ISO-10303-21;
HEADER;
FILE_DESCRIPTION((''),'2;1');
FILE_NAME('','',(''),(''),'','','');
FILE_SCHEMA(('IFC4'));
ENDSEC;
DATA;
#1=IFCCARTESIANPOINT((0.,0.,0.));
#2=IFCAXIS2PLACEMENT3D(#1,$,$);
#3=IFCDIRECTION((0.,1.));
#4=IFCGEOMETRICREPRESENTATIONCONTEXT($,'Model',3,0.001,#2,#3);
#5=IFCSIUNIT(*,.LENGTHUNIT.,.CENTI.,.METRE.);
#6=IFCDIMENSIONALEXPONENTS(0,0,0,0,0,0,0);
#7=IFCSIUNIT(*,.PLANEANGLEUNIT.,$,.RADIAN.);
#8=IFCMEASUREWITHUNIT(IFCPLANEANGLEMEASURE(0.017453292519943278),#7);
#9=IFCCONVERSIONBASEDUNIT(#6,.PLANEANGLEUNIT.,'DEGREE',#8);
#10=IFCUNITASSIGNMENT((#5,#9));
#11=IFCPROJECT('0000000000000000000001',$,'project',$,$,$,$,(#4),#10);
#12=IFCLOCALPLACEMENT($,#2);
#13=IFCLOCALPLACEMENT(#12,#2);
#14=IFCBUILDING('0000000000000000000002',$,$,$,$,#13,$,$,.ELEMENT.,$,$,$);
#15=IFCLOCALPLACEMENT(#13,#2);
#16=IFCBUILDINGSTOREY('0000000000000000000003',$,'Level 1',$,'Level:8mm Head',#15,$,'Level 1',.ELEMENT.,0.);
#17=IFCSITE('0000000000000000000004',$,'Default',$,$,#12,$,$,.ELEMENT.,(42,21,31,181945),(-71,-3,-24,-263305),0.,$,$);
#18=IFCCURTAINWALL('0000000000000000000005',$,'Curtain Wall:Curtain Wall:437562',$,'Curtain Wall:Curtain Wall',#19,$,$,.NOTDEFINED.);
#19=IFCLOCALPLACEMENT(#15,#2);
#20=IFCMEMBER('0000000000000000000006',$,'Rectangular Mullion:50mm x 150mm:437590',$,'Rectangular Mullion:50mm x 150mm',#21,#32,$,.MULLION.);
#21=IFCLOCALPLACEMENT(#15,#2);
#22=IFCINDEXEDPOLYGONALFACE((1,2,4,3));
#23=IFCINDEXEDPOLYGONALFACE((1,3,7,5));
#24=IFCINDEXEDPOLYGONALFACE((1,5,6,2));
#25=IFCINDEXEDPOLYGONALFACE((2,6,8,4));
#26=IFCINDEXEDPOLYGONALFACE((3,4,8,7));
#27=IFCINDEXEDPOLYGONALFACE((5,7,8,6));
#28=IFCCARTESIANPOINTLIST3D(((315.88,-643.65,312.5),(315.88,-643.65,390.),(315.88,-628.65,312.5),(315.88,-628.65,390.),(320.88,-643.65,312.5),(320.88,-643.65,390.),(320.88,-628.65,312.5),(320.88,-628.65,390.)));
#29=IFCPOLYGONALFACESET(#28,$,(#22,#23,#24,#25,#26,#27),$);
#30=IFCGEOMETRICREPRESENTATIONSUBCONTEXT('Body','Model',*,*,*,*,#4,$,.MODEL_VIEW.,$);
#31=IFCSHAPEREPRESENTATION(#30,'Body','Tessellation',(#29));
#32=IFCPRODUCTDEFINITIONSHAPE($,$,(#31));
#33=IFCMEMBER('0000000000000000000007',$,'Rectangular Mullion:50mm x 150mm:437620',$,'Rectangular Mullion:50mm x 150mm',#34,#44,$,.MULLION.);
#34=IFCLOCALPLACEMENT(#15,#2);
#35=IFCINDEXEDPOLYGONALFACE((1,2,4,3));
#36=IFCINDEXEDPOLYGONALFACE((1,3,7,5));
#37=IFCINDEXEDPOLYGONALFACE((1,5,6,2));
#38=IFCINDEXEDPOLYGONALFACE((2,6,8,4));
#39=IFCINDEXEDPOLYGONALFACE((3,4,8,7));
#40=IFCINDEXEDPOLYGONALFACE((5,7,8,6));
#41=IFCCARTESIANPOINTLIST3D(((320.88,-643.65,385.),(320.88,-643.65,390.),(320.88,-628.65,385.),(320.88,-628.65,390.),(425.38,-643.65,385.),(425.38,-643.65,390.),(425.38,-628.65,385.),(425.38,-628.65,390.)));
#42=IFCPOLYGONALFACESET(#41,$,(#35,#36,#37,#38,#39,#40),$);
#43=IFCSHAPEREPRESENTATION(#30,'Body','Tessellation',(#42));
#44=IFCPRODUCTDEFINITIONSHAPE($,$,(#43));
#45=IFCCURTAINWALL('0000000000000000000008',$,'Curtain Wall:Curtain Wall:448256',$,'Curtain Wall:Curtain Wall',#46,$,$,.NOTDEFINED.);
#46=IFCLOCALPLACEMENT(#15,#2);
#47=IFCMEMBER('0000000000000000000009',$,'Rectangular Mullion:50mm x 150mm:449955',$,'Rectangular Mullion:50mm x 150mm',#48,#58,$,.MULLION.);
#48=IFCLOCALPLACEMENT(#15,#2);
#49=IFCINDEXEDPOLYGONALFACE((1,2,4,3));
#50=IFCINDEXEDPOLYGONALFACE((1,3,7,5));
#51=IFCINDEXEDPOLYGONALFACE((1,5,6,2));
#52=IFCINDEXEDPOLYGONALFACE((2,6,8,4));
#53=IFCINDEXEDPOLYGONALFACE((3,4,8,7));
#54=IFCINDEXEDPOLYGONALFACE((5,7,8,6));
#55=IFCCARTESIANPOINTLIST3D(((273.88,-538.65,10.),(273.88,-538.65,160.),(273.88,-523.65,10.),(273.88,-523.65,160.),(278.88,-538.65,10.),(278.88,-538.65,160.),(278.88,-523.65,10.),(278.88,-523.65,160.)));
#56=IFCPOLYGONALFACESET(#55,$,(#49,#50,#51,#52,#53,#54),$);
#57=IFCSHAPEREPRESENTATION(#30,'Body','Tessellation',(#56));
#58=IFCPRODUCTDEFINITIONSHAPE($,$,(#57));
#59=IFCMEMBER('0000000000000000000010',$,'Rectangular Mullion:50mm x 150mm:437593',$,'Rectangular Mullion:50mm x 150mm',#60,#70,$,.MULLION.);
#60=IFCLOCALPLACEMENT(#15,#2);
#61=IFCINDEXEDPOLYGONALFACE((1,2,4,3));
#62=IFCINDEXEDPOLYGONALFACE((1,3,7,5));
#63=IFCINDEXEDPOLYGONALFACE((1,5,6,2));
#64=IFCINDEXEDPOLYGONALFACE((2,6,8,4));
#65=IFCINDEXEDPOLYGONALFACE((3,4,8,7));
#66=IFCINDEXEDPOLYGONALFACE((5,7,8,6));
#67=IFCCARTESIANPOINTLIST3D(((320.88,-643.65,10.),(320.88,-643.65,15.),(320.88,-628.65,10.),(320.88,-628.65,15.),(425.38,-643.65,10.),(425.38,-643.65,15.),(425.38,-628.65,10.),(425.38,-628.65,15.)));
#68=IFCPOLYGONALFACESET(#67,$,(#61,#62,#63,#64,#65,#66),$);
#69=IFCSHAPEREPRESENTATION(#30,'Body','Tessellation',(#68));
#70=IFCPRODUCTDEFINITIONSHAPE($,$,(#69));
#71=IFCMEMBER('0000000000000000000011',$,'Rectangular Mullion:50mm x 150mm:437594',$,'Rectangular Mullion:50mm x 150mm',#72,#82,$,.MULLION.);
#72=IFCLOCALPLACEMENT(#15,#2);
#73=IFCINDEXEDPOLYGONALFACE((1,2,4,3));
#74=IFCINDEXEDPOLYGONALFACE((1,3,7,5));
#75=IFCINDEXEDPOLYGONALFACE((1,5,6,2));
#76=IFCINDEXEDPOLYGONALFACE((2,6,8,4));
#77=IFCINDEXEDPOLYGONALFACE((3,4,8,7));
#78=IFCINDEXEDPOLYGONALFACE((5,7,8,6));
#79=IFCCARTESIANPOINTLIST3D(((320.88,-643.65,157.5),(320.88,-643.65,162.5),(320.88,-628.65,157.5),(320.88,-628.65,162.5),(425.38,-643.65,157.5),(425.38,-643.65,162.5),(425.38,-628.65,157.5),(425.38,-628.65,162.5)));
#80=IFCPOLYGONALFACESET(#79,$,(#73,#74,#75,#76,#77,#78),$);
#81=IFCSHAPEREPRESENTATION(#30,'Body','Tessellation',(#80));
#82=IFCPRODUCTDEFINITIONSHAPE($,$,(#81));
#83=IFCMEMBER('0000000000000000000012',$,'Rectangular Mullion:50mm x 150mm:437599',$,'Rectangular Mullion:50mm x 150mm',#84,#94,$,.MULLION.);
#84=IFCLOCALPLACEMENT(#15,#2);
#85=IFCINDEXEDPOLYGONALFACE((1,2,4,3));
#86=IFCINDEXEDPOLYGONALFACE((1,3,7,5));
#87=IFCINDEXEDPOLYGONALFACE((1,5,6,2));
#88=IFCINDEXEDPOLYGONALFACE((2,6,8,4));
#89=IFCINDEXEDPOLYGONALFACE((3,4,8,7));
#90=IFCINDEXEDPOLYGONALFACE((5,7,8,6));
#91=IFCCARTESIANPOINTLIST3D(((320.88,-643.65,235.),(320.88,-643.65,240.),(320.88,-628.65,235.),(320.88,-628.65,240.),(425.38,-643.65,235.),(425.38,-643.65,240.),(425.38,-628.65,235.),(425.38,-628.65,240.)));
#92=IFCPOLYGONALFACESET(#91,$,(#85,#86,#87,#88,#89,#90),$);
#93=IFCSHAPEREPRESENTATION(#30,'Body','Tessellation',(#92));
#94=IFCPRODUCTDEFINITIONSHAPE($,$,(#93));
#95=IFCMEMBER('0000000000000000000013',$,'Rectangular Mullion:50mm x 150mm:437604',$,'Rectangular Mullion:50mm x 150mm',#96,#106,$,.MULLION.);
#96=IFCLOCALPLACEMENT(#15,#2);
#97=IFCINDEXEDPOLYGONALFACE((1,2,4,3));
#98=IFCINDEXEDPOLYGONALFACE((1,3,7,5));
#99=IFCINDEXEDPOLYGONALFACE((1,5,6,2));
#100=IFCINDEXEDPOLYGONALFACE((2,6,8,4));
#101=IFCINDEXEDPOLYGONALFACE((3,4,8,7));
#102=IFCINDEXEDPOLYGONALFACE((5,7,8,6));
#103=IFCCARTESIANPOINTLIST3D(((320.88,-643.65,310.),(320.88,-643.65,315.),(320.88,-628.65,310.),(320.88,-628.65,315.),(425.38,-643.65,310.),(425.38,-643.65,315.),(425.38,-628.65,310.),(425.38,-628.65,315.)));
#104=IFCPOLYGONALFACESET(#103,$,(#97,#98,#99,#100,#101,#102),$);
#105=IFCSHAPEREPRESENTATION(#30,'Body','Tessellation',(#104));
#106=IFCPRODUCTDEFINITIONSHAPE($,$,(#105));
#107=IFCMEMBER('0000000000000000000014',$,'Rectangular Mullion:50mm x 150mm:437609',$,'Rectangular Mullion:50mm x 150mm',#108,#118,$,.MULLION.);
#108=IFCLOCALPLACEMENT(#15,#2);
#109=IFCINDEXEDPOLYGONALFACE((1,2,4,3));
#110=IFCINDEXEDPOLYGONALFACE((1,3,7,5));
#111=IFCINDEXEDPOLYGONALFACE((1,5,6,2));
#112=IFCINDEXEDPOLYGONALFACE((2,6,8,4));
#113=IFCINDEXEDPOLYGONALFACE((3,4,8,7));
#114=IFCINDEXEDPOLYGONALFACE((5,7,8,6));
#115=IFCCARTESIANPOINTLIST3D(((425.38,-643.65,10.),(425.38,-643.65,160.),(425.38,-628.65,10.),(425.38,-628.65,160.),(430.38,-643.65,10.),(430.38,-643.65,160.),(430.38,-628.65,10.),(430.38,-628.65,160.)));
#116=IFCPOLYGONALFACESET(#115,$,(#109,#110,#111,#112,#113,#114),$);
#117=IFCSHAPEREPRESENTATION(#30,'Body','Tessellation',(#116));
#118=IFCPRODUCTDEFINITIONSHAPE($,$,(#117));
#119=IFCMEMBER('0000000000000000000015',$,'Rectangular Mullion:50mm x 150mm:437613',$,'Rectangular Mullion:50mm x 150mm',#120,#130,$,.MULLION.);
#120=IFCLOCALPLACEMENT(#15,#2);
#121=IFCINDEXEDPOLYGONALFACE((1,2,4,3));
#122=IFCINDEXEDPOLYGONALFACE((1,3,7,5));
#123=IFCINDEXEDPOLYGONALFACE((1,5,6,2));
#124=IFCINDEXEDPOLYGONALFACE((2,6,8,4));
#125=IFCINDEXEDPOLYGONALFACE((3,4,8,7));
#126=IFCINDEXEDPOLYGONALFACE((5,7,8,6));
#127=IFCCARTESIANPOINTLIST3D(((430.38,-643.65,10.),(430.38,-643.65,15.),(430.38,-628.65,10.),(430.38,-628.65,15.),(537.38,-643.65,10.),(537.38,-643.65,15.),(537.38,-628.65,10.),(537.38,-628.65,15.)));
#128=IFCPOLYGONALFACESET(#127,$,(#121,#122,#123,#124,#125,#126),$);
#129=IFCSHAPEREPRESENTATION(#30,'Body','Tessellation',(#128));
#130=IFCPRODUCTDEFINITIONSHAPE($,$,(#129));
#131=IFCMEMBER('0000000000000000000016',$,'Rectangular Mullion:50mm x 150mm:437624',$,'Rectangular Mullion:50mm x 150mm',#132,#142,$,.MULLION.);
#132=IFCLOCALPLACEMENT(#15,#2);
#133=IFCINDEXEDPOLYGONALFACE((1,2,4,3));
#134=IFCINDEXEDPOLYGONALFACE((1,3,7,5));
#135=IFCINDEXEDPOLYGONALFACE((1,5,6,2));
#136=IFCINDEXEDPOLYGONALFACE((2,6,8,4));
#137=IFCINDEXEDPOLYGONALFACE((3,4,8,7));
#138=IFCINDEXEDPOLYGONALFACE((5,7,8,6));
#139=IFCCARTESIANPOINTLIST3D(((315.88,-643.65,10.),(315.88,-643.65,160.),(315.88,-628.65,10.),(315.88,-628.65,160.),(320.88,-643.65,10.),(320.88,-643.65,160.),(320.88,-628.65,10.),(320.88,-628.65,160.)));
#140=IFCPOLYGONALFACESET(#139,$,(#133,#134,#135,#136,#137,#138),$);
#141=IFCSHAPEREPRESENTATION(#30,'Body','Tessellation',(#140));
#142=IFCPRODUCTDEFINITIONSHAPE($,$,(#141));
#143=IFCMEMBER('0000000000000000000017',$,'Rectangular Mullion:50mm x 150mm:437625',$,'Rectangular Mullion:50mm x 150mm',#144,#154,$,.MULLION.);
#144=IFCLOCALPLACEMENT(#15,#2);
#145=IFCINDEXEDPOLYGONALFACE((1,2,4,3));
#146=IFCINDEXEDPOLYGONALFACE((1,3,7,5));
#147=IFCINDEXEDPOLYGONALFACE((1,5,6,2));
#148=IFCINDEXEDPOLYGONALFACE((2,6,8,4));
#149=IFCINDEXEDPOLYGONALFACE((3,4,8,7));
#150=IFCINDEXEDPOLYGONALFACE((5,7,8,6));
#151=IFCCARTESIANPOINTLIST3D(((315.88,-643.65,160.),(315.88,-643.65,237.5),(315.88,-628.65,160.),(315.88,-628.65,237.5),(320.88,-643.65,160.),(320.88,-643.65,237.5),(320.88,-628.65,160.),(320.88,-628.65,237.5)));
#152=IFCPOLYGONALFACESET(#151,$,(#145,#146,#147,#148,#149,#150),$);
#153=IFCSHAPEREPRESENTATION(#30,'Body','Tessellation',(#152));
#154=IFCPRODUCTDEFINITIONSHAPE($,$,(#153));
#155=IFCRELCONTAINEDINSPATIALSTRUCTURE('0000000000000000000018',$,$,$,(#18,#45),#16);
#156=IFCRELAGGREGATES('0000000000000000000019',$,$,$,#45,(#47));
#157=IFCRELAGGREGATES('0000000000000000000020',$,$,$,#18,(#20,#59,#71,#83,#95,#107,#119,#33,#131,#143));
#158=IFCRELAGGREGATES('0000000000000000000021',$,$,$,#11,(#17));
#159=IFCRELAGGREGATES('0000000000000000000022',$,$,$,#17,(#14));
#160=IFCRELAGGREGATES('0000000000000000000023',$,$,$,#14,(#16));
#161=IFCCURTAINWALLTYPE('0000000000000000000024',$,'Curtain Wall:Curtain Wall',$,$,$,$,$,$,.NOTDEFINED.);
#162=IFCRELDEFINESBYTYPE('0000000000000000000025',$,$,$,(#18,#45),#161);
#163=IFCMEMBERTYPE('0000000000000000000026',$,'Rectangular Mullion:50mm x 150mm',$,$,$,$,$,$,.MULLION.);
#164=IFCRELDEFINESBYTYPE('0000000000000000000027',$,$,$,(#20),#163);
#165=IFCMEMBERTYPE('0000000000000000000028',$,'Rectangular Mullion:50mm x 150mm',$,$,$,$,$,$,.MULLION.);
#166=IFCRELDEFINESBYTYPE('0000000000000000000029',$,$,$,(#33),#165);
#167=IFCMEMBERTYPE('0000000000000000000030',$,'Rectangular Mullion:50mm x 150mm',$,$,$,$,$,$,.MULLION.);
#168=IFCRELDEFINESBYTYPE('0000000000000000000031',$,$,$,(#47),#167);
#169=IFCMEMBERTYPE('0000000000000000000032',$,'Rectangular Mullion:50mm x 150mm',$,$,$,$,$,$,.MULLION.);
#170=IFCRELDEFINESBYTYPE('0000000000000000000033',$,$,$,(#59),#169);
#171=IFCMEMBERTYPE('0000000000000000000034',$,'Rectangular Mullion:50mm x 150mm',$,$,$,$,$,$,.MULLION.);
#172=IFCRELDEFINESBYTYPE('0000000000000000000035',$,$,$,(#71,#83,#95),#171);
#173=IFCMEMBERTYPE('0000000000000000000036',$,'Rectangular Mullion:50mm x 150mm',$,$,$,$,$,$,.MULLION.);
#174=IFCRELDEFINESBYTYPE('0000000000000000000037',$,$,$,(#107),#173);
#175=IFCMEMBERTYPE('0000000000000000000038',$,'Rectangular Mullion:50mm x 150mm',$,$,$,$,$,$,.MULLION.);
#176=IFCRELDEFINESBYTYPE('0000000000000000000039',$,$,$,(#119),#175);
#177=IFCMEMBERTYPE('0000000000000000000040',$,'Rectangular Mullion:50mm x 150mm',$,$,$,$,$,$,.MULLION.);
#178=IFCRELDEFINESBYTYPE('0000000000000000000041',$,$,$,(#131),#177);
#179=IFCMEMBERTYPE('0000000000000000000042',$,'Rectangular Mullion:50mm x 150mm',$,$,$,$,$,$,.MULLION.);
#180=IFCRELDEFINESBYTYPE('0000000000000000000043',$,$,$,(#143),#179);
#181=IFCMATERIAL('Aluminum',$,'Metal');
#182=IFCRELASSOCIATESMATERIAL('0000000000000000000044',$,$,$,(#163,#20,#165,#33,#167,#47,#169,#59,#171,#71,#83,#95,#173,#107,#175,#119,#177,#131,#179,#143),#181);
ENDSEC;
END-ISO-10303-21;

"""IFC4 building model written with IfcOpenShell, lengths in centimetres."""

from ifc_helpers import new_model, entity, si_unit, converted_unit, direction, frame, origin, place, context, subcontext, project, spatial, indexed_curve, outline, extrude, source, transform, mapped, material, type_object, type_shapes, element, aggregate, save


model = new_model("IFC4")

# Units and contexts
model_context = context("Model", 3, precision=0.001, world=origin(), true_north=direction((0.0, 1.0)))
body_context = subcontext(model_context, "Body", "Model", "MODEL_VIEW")
ifc_project = project(units=[si_unit("LENGTHUNIT", "METRE", prefix="CENTI"), converted_unit("PLANEANGLEUNIT", "DEGREE", entity("IfcPlaneAngleMeasure", 0.017453292519943278), si_unit("PLANEANGLEUNIT", "RADIAN"), dimensions=[0, 0, 0, 0, 0, 0, 0])], contexts=[model_context])

# Site, building, storey
site_placement = place(None, origin())
site = spatial("IfcSite", under=ifc_project, at=site_placement, Name="Default", CompositionType="ELEMENT", RefLatitude=(42, 21, 31, 181945), RefLongitude=(-71, -3, -24, -263305), RefElevation=0.0)
building_placement = place(site_placement, origin())
building = spatial("IfcBuilding", under=site, at=building_placement, CompositionType="ELEMENT")
storey_placement = place(building_placement, origin())
storey = spatial("IfcBuildingStorey", under=building, at=storey_placement, Name="Level 1", ObjectType="Level:8mm Head", LongName="Level 1", CompositionType="ELEMENT", Elevation=0.0)

# Curtain wall, members
curtain_wall_type = type_object("IfcCurtainWallType", Name="Curtain Wall:Curtain Wall", PredefinedType="NOTDEFINED")
curtain_wall_1_placement = place(storey_placement, origin())
curtain_wall_1 = element("IfcCurtainWall", 1, at=curtain_wall_1_placement, inside=storey, type_object=curtain_wall_type, Name="Curtain Wall:Curtain Wall:437562", ObjectType="Curtain Wall:Curtain Wall", PredefinedType="NOTDEFINED")
ifc_material_1 = material(Name="Aluminum", Category="Metal")
member_type_1 = type_object("IfcMemberType", Name="Rectangular Mullion:50mm x 150mm", PredefinedType="MULLION", material=ifc_material_1)
shared_shape_1 = source(origin(), body_context, "Body", "SweptSolid", [
    extrude(outline(indexed_curve([(-2.5, -7.5), (2.5, -7.5), (2.5, 7.5), (-2.5, 7.5), (-2.5, -7.5)], self_intersect=False)), frame((-2.5, 0.0, -77.5), z_axis=(0.0, 0.0, 1.0), x_axis=(-1.0, 0.0, 0.0)), (0.0, 0.0, 1.0), 77.5),
])
type_shapes(member_type_1, [shared_shape_1])
member_1_placement = place(curtain_wall_1_placement, frame((315.88, -636.15, 390.0), z_axis=(0.0, 0.0, 1.0), x_axis=(-1.0, 0.0, 0.0)))
member_1 = element("IfcMember", 2, at=member_1_placement, type_object=member_type_1, material=ifc_material_1, Name="Rectangular Mullion:50mm x 150mm:437590", ObjectType="Rectangular Mullion:50mm x 150mm", PredefinedType="MULLION", context=body_context, shape_type="MappedRepresentation", body=[
    mapped(shared_shape_1, transform((0.0, 0.0, 0.0), scale=1.0)),
])
member_type_2 = type_object("IfcMemberType", Name="Rectangular Mullion:50mm x 150mm", PredefinedType="MULLION", material=ifc_material_1)
shared_shape_2 = source(origin(), body_context, "Body", "SweptSolid", [
    extrude(outline(indexed_curve([(-2.5, -7.5), (2.5, -7.5), (2.5, 7.5), (-2.5, 7.5), (-2.5, -7.5)], self_intersect=False)), frame((-2.5, 0.0, -104.5), z_axis=(0.0, 0.0, 1.0), x_axis=(-1.0, 0.0, 0.0)), (0.0, 0.0, 1.0), 104.5),
])
type_shapes(member_type_2, [shared_shape_2])
member_2_placement = place(curtain_wall_1_placement, frame((425.38, -636.15, 390.0), z_axis=(1.0, 0.0, 0.0), x_axis=(0.0, 0.0, 1.0)))
member_2 = element("IfcMember", 3, at=member_2_placement, type_object=member_type_2, material=ifc_material_1, Name="Rectangular Mullion:50mm x 150mm:437620", ObjectType="Rectangular Mullion:50mm x 150mm", PredefinedType="MULLION", context=body_context, shape_type="MappedRepresentation", body=[
    mapped(shared_shape_2, transform((0.0, 0.0, 0.0), scale=1.0)),
])

# Curtain wall, member
curtain_wall_2_placement = place(storey_placement, origin())
curtain_wall_2 = element("IfcCurtainWall", 4, at=curtain_wall_2_placement, inside=storey, type_object=curtain_wall_type, Name="Curtain Wall:Curtain Wall:448256", ObjectType="Curtain Wall:Curtain Wall", PredefinedType="NOTDEFINED")
member_type_3 = type_object("IfcMemberType", Name="Rectangular Mullion:50mm x 150mm", PredefinedType="MULLION", material=ifc_material_1)
shared_shape_3 = source(origin(), body_context, "Body", "SweptSolid", [
    extrude(outline(indexed_curve([(-2.5, -7.5), (2.5, -7.5), (2.5, 7.5), (-2.5, 7.5), (-2.5, -7.5)], self_intersect=False)), frame((-2.5, 0.0, -150.0), z_axis=(0.0, 0.0, 1.0), x_axis=(-1.0, 0.0, 0.0)), (0.0, 0.0, 1.0), 150.0),
])
type_shapes(member_type_3, [shared_shape_3])
member_3_placement = place(curtain_wall_2_placement, frame((278.88, -531.15, 10.0), z_axis=(0.0, 0.0, -1.0), x_axis=(1.0, 0.0, 0.0)))
member_3 = element("IfcMember", 5, at=member_3_placement, type_object=member_type_3, material=ifc_material_1, Name="Rectangular Mullion:50mm x 150mm:449955", ObjectType="Rectangular Mullion:50mm x 150mm", PredefinedType="MULLION", context=body_context, shape_type="MappedRepresentation", body=[
    mapped(shared_shape_3, transform((0.0, 0.0, 0.0), scale=1.0)),
])

# Members
member_type_4 = type_object("IfcMemberType", Name="Rectangular Mullion:50mm x 150mm", PredefinedType="MULLION", material=ifc_material_1)
shared_shape_4 = source(origin(), body_context, "Body", "SweptSolid", [
    extrude(outline(indexed_curve([(-2.5, -7.5), (2.5, -7.5), (2.5, 7.5), (-2.5, 7.5), (-2.5, -7.5)], self_intersect=False)), frame((-2.5, 0.0, -104.5), z_axis=(0.0, 0.0, 1.0), x_axis=(-1.0, 0.0, 0.0)), (0.0, 0.0, 1.0), 104.5),
])
type_shapes(member_type_4, [shared_shape_4])
member_4_placement = place(curtain_wall_1_placement, frame((320.88, -636.15, 10.0), z_axis=(-1.0, 0.0, 0.0), x_axis=(0.0, 0.0, -1.0)))
member_4 = element("IfcMember", 6, at=member_4_placement, type_object=member_type_4, material=ifc_material_1, Name="Rectangular Mullion:50mm x 150mm:437593", ObjectType="Rectangular Mullion:50mm x 150mm", PredefinedType="MULLION", context=body_context, shape_type="MappedRepresentation", body=[
    mapped(shared_shape_4, transform((0.0, 0.0, 0.0), scale=1.0)),
])
member_type_5 = type_object("IfcMemberType", Name="Rectangular Mullion:50mm x 150mm", PredefinedType="MULLION", material=ifc_material_1)
shared_shape_5 = source(origin(), body_context, "Body", "SweptSolid", [
    extrude(outline(indexed_curve([(-2.5, -7.5), (2.5, -7.5), (2.5, 7.5), (-2.5, 7.5), (-2.5, -7.5)], self_intersect=False)), frame((0.0, 0.0, -104.5), z_axis=(0.0, 0.0, 1.0), x_axis=(-1.0, 0.0, 0.0)), (0.0, 0.0, 1.0), 104.5),
])
type_shapes(member_type_5, [shared_shape_5])
member_5_placement = place(curtain_wall_1_placement, frame((425.38, -636.15, 160.0), z_axis=(1.0, 0.0, 0.0), x_axis=(0.0, 0.0, 1.0)))
member_5 = element("IfcMember", 7, at=member_5_placement, type_object=member_type_5, material=ifc_material_1, Name="Rectangular Mullion:50mm x 150mm:437594", ObjectType="Rectangular Mullion:50mm x 150mm", PredefinedType="MULLION", context=body_context, shape_type="MappedRepresentation", body=[
    mapped(shared_shape_5, transform((0.0, 0.0, 0.0), scale=1.0)),
])
member_6_placement = place(curtain_wall_1_placement, frame((425.38, -636.15, 237.5), z_axis=(1.0, 0.0, 0.0), x_axis=(0.0, 0.0, 1.0)))
member_6 = element("IfcMember", 8, at=member_6_placement, type_object=member_type_5, material=ifc_material_1, Name="Rectangular Mullion:50mm x 150mm:437599", ObjectType="Rectangular Mullion:50mm x 150mm", PredefinedType="MULLION", context=body_context, shape_type="MappedRepresentation", body=[
    mapped(shared_shape_5, transform((0.0, 0.0, 0.0), scale=1.0)),
])
member_7_placement = place(curtain_wall_1_placement, frame((425.38, -636.15, 312.5), z_axis=(1.0, 0.0, 0.0), x_axis=(0.0, 0.0, 1.0)))
member_7 = element("IfcMember", 9, at=member_7_placement, type_object=member_type_5, material=ifc_material_1, Name="Rectangular Mullion:50mm x 150mm:437604", ObjectType="Rectangular Mullion:50mm x 150mm", PredefinedType="MULLION", context=body_context, shape_type="MappedRepresentation", body=[
    mapped(shared_shape_5, transform((0.0, 0.0, 0.0), scale=1.0)),
])
member_type_6 = type_object("IfcMemberType", Name="Rectangular Mullion:50mm x 150mm", PredefinedType="MULLION", material=ifc_material_1)
shared_shape_6 = source(origin(), body_context, "Body", "SweptSolid", [
    extrude(outline(indexed_curve([(-2.5, -7.5), (2.5, -7.5), (2.5, 7.5), (-2.5, 7.5), (-2.5, -7.5)], self_intersect=False)), frame((0.0, 0.0, -150.0), z_axis=(0.0, 0.0, 1.0), x_axis=(-1.0, 0.0, 0.0)), (0.0, 0.0, 1.0), 150.0),
])
type_shapes(member_type_6, [shared_shape_6])
member_8_placement = place(curtain_wall_1_placement, frame((427.88, -636.15, 10.0), z_axis=(0.0, 0.0, -1.0), x_axis=(1.0, 0.0, 0.0)))
member_8 = element("IfcMember", 10, at=member_8_placement, type_object=member_type_6, material=ifc_material_1, Name="Rectangular Mullion:50mm x 150mm:437609", ObjectType="Rectangular Mullion:50mm x 150mm", PredefinedType="MULLION", context=body_context, shape_type="MappedRepresentation", body=[
    mapped(shared_shape_6, transform((0.0, 0.0, 0.0), scale=1.0)),
])
member_type_7 = type_object("IfcMemberType", Name="Rectangular Mullion:50mm x 150mm", PredefinedType="MULLION", material=ifc_material_1)
shared_shape_7 = source(origin(), body_context, "Body", "SweptSolid", [
    extrude(outline(indexed_curve([(-2.5, -7.5), (2.5, -7.5), (2.5, 7.5), (-2.5, 7.5), (-2.5, -7.5)], self_intersect=False)), frame((-2.5, 0.0, -107.0), z_axis=(0.0, 0.0, 1.0), x_axis=(-1.0, 0.0, 0.0)), (0.0, 0.0, 1.0), 107.0),
])
type_shapes(member_type_7, [shared_shape_7])
member_9_placement = place(curtain_wall_1_placement, frame((430.38, -636.15, 10.0), z_axis=(-1.0, 0.0, 0.0), x_axis=(0.0, 0.0, -1.0)))
member_9 = element("IfcMember", 11, at=member_9_placement, type_object=member_type_7, material=ifc_material_1, Name="Rectangular Mullion:50mm x 150mm:437613", ObjectType="Rectangular Mullion:50mm x 150mm", PredefinedType="MULLION", context=body_context, shape_type="MappedRepresentation", body=[
    mapped(shared_shape_7, transform((0.0, 0.0, 0.0), scale=1.0)),
])
member_type_8 = type_object("IfcMemberType", Name="Rectangular Mullion:50mm x 150mm", PredefinedType="MULLION", material=ifc_material_1)
shared_shape_8 = source(origin(), body_context, "Body", "SweptSolid", [
    extrude(outline(indexed_curve([(-2.5, -7.5), (2.5, -7.5), (2.5, 7.5), (-2.5, 7.5), (-2.5, -7.5)], self_intersect=False)), frame((-2.5, 0.0, -150.0), z_axis=(0.0, 0.0, 1.0), x_axis=(-1.0, 0.0, 0.0)), (0.0, 0.0, 1.0), 150.0),
])
type_shapes(member_type_8, [shared_shape_8])
member_10_placement = place(curtain_wall_1_placement, frame((315.88, -636.15, 160.0), z_axis=(0.0, 0.0, 1.0), x_axis=(-1.0, 0.0, 0.0)))
member_10 = element("IfcMember", 12, at=member_10_placement, type_object=member_type_8, material=ifc_material_1, Name="Rectangular Mullion:50mm x 150mm:437624", ObjectType="Rectangular Mullion:50mm x 150mm", PredefinedType="MULLION", context=body_context, shape_type="MappedRepresentation", body=[
    mapped(shared_shape_8, transform((0.0, 0.0, 0.0), scale=1.0)),
])
member_type_9 = type_object("IfcMemberType", Name="Rectangular Mullion:50mm x 150mm", PredefinedType="MULLION", material=ifc_material_1)
shared_shape_9 = source(origin(), body_context, "Body", "SweptSolid", [
    extrude(outline(indexed_curve([(-2.5, -7.5), (2.5, -7.5), (2.5, 7.5), (-2.5, 7.5), (-2.5, -7.5)], self_intersect=False)), frame((-2.5, 0.0, -77.5), z_axis=(0.0, 0.0, 1.0), x_axis=(-1.0, 0.0, 0.0)), (0.0, 0.0, 1.0), 77.5),
])
type_shapes(member_type_9, [shared_shape_9])
member_11_placement = place(curtain_wall_1_placement, frame((315.88, -636.15, 237.5), z_axis=(0.0, 0.0, 1.0), x_axis=(-1.0, 0.0, 0.0)))
member_11 = element("IfcMember", 13, at=member_11_placement, type_object=member_type_9, material=ifc_material_1, Name="Rectangular Mullion:50mm x 150mm:437625", ObjectType="Rectangular Mullion:50mm x 150mm", PredefinedType="MULLION", context=body_context, shape_type="MappedRepresentation", body=[
    mapped(shared_shape_9, transform((0.0, 0.0, 0.0), scale=1.0)),
])
aggregate(curtain_wall_2, [member_3])

aggregate(curtain_wall_1, [member_1, member_4, member_5, member_6, member_7, member_8, member_9, member_2, member_10, member_11])

save(model, "model.ifc")
